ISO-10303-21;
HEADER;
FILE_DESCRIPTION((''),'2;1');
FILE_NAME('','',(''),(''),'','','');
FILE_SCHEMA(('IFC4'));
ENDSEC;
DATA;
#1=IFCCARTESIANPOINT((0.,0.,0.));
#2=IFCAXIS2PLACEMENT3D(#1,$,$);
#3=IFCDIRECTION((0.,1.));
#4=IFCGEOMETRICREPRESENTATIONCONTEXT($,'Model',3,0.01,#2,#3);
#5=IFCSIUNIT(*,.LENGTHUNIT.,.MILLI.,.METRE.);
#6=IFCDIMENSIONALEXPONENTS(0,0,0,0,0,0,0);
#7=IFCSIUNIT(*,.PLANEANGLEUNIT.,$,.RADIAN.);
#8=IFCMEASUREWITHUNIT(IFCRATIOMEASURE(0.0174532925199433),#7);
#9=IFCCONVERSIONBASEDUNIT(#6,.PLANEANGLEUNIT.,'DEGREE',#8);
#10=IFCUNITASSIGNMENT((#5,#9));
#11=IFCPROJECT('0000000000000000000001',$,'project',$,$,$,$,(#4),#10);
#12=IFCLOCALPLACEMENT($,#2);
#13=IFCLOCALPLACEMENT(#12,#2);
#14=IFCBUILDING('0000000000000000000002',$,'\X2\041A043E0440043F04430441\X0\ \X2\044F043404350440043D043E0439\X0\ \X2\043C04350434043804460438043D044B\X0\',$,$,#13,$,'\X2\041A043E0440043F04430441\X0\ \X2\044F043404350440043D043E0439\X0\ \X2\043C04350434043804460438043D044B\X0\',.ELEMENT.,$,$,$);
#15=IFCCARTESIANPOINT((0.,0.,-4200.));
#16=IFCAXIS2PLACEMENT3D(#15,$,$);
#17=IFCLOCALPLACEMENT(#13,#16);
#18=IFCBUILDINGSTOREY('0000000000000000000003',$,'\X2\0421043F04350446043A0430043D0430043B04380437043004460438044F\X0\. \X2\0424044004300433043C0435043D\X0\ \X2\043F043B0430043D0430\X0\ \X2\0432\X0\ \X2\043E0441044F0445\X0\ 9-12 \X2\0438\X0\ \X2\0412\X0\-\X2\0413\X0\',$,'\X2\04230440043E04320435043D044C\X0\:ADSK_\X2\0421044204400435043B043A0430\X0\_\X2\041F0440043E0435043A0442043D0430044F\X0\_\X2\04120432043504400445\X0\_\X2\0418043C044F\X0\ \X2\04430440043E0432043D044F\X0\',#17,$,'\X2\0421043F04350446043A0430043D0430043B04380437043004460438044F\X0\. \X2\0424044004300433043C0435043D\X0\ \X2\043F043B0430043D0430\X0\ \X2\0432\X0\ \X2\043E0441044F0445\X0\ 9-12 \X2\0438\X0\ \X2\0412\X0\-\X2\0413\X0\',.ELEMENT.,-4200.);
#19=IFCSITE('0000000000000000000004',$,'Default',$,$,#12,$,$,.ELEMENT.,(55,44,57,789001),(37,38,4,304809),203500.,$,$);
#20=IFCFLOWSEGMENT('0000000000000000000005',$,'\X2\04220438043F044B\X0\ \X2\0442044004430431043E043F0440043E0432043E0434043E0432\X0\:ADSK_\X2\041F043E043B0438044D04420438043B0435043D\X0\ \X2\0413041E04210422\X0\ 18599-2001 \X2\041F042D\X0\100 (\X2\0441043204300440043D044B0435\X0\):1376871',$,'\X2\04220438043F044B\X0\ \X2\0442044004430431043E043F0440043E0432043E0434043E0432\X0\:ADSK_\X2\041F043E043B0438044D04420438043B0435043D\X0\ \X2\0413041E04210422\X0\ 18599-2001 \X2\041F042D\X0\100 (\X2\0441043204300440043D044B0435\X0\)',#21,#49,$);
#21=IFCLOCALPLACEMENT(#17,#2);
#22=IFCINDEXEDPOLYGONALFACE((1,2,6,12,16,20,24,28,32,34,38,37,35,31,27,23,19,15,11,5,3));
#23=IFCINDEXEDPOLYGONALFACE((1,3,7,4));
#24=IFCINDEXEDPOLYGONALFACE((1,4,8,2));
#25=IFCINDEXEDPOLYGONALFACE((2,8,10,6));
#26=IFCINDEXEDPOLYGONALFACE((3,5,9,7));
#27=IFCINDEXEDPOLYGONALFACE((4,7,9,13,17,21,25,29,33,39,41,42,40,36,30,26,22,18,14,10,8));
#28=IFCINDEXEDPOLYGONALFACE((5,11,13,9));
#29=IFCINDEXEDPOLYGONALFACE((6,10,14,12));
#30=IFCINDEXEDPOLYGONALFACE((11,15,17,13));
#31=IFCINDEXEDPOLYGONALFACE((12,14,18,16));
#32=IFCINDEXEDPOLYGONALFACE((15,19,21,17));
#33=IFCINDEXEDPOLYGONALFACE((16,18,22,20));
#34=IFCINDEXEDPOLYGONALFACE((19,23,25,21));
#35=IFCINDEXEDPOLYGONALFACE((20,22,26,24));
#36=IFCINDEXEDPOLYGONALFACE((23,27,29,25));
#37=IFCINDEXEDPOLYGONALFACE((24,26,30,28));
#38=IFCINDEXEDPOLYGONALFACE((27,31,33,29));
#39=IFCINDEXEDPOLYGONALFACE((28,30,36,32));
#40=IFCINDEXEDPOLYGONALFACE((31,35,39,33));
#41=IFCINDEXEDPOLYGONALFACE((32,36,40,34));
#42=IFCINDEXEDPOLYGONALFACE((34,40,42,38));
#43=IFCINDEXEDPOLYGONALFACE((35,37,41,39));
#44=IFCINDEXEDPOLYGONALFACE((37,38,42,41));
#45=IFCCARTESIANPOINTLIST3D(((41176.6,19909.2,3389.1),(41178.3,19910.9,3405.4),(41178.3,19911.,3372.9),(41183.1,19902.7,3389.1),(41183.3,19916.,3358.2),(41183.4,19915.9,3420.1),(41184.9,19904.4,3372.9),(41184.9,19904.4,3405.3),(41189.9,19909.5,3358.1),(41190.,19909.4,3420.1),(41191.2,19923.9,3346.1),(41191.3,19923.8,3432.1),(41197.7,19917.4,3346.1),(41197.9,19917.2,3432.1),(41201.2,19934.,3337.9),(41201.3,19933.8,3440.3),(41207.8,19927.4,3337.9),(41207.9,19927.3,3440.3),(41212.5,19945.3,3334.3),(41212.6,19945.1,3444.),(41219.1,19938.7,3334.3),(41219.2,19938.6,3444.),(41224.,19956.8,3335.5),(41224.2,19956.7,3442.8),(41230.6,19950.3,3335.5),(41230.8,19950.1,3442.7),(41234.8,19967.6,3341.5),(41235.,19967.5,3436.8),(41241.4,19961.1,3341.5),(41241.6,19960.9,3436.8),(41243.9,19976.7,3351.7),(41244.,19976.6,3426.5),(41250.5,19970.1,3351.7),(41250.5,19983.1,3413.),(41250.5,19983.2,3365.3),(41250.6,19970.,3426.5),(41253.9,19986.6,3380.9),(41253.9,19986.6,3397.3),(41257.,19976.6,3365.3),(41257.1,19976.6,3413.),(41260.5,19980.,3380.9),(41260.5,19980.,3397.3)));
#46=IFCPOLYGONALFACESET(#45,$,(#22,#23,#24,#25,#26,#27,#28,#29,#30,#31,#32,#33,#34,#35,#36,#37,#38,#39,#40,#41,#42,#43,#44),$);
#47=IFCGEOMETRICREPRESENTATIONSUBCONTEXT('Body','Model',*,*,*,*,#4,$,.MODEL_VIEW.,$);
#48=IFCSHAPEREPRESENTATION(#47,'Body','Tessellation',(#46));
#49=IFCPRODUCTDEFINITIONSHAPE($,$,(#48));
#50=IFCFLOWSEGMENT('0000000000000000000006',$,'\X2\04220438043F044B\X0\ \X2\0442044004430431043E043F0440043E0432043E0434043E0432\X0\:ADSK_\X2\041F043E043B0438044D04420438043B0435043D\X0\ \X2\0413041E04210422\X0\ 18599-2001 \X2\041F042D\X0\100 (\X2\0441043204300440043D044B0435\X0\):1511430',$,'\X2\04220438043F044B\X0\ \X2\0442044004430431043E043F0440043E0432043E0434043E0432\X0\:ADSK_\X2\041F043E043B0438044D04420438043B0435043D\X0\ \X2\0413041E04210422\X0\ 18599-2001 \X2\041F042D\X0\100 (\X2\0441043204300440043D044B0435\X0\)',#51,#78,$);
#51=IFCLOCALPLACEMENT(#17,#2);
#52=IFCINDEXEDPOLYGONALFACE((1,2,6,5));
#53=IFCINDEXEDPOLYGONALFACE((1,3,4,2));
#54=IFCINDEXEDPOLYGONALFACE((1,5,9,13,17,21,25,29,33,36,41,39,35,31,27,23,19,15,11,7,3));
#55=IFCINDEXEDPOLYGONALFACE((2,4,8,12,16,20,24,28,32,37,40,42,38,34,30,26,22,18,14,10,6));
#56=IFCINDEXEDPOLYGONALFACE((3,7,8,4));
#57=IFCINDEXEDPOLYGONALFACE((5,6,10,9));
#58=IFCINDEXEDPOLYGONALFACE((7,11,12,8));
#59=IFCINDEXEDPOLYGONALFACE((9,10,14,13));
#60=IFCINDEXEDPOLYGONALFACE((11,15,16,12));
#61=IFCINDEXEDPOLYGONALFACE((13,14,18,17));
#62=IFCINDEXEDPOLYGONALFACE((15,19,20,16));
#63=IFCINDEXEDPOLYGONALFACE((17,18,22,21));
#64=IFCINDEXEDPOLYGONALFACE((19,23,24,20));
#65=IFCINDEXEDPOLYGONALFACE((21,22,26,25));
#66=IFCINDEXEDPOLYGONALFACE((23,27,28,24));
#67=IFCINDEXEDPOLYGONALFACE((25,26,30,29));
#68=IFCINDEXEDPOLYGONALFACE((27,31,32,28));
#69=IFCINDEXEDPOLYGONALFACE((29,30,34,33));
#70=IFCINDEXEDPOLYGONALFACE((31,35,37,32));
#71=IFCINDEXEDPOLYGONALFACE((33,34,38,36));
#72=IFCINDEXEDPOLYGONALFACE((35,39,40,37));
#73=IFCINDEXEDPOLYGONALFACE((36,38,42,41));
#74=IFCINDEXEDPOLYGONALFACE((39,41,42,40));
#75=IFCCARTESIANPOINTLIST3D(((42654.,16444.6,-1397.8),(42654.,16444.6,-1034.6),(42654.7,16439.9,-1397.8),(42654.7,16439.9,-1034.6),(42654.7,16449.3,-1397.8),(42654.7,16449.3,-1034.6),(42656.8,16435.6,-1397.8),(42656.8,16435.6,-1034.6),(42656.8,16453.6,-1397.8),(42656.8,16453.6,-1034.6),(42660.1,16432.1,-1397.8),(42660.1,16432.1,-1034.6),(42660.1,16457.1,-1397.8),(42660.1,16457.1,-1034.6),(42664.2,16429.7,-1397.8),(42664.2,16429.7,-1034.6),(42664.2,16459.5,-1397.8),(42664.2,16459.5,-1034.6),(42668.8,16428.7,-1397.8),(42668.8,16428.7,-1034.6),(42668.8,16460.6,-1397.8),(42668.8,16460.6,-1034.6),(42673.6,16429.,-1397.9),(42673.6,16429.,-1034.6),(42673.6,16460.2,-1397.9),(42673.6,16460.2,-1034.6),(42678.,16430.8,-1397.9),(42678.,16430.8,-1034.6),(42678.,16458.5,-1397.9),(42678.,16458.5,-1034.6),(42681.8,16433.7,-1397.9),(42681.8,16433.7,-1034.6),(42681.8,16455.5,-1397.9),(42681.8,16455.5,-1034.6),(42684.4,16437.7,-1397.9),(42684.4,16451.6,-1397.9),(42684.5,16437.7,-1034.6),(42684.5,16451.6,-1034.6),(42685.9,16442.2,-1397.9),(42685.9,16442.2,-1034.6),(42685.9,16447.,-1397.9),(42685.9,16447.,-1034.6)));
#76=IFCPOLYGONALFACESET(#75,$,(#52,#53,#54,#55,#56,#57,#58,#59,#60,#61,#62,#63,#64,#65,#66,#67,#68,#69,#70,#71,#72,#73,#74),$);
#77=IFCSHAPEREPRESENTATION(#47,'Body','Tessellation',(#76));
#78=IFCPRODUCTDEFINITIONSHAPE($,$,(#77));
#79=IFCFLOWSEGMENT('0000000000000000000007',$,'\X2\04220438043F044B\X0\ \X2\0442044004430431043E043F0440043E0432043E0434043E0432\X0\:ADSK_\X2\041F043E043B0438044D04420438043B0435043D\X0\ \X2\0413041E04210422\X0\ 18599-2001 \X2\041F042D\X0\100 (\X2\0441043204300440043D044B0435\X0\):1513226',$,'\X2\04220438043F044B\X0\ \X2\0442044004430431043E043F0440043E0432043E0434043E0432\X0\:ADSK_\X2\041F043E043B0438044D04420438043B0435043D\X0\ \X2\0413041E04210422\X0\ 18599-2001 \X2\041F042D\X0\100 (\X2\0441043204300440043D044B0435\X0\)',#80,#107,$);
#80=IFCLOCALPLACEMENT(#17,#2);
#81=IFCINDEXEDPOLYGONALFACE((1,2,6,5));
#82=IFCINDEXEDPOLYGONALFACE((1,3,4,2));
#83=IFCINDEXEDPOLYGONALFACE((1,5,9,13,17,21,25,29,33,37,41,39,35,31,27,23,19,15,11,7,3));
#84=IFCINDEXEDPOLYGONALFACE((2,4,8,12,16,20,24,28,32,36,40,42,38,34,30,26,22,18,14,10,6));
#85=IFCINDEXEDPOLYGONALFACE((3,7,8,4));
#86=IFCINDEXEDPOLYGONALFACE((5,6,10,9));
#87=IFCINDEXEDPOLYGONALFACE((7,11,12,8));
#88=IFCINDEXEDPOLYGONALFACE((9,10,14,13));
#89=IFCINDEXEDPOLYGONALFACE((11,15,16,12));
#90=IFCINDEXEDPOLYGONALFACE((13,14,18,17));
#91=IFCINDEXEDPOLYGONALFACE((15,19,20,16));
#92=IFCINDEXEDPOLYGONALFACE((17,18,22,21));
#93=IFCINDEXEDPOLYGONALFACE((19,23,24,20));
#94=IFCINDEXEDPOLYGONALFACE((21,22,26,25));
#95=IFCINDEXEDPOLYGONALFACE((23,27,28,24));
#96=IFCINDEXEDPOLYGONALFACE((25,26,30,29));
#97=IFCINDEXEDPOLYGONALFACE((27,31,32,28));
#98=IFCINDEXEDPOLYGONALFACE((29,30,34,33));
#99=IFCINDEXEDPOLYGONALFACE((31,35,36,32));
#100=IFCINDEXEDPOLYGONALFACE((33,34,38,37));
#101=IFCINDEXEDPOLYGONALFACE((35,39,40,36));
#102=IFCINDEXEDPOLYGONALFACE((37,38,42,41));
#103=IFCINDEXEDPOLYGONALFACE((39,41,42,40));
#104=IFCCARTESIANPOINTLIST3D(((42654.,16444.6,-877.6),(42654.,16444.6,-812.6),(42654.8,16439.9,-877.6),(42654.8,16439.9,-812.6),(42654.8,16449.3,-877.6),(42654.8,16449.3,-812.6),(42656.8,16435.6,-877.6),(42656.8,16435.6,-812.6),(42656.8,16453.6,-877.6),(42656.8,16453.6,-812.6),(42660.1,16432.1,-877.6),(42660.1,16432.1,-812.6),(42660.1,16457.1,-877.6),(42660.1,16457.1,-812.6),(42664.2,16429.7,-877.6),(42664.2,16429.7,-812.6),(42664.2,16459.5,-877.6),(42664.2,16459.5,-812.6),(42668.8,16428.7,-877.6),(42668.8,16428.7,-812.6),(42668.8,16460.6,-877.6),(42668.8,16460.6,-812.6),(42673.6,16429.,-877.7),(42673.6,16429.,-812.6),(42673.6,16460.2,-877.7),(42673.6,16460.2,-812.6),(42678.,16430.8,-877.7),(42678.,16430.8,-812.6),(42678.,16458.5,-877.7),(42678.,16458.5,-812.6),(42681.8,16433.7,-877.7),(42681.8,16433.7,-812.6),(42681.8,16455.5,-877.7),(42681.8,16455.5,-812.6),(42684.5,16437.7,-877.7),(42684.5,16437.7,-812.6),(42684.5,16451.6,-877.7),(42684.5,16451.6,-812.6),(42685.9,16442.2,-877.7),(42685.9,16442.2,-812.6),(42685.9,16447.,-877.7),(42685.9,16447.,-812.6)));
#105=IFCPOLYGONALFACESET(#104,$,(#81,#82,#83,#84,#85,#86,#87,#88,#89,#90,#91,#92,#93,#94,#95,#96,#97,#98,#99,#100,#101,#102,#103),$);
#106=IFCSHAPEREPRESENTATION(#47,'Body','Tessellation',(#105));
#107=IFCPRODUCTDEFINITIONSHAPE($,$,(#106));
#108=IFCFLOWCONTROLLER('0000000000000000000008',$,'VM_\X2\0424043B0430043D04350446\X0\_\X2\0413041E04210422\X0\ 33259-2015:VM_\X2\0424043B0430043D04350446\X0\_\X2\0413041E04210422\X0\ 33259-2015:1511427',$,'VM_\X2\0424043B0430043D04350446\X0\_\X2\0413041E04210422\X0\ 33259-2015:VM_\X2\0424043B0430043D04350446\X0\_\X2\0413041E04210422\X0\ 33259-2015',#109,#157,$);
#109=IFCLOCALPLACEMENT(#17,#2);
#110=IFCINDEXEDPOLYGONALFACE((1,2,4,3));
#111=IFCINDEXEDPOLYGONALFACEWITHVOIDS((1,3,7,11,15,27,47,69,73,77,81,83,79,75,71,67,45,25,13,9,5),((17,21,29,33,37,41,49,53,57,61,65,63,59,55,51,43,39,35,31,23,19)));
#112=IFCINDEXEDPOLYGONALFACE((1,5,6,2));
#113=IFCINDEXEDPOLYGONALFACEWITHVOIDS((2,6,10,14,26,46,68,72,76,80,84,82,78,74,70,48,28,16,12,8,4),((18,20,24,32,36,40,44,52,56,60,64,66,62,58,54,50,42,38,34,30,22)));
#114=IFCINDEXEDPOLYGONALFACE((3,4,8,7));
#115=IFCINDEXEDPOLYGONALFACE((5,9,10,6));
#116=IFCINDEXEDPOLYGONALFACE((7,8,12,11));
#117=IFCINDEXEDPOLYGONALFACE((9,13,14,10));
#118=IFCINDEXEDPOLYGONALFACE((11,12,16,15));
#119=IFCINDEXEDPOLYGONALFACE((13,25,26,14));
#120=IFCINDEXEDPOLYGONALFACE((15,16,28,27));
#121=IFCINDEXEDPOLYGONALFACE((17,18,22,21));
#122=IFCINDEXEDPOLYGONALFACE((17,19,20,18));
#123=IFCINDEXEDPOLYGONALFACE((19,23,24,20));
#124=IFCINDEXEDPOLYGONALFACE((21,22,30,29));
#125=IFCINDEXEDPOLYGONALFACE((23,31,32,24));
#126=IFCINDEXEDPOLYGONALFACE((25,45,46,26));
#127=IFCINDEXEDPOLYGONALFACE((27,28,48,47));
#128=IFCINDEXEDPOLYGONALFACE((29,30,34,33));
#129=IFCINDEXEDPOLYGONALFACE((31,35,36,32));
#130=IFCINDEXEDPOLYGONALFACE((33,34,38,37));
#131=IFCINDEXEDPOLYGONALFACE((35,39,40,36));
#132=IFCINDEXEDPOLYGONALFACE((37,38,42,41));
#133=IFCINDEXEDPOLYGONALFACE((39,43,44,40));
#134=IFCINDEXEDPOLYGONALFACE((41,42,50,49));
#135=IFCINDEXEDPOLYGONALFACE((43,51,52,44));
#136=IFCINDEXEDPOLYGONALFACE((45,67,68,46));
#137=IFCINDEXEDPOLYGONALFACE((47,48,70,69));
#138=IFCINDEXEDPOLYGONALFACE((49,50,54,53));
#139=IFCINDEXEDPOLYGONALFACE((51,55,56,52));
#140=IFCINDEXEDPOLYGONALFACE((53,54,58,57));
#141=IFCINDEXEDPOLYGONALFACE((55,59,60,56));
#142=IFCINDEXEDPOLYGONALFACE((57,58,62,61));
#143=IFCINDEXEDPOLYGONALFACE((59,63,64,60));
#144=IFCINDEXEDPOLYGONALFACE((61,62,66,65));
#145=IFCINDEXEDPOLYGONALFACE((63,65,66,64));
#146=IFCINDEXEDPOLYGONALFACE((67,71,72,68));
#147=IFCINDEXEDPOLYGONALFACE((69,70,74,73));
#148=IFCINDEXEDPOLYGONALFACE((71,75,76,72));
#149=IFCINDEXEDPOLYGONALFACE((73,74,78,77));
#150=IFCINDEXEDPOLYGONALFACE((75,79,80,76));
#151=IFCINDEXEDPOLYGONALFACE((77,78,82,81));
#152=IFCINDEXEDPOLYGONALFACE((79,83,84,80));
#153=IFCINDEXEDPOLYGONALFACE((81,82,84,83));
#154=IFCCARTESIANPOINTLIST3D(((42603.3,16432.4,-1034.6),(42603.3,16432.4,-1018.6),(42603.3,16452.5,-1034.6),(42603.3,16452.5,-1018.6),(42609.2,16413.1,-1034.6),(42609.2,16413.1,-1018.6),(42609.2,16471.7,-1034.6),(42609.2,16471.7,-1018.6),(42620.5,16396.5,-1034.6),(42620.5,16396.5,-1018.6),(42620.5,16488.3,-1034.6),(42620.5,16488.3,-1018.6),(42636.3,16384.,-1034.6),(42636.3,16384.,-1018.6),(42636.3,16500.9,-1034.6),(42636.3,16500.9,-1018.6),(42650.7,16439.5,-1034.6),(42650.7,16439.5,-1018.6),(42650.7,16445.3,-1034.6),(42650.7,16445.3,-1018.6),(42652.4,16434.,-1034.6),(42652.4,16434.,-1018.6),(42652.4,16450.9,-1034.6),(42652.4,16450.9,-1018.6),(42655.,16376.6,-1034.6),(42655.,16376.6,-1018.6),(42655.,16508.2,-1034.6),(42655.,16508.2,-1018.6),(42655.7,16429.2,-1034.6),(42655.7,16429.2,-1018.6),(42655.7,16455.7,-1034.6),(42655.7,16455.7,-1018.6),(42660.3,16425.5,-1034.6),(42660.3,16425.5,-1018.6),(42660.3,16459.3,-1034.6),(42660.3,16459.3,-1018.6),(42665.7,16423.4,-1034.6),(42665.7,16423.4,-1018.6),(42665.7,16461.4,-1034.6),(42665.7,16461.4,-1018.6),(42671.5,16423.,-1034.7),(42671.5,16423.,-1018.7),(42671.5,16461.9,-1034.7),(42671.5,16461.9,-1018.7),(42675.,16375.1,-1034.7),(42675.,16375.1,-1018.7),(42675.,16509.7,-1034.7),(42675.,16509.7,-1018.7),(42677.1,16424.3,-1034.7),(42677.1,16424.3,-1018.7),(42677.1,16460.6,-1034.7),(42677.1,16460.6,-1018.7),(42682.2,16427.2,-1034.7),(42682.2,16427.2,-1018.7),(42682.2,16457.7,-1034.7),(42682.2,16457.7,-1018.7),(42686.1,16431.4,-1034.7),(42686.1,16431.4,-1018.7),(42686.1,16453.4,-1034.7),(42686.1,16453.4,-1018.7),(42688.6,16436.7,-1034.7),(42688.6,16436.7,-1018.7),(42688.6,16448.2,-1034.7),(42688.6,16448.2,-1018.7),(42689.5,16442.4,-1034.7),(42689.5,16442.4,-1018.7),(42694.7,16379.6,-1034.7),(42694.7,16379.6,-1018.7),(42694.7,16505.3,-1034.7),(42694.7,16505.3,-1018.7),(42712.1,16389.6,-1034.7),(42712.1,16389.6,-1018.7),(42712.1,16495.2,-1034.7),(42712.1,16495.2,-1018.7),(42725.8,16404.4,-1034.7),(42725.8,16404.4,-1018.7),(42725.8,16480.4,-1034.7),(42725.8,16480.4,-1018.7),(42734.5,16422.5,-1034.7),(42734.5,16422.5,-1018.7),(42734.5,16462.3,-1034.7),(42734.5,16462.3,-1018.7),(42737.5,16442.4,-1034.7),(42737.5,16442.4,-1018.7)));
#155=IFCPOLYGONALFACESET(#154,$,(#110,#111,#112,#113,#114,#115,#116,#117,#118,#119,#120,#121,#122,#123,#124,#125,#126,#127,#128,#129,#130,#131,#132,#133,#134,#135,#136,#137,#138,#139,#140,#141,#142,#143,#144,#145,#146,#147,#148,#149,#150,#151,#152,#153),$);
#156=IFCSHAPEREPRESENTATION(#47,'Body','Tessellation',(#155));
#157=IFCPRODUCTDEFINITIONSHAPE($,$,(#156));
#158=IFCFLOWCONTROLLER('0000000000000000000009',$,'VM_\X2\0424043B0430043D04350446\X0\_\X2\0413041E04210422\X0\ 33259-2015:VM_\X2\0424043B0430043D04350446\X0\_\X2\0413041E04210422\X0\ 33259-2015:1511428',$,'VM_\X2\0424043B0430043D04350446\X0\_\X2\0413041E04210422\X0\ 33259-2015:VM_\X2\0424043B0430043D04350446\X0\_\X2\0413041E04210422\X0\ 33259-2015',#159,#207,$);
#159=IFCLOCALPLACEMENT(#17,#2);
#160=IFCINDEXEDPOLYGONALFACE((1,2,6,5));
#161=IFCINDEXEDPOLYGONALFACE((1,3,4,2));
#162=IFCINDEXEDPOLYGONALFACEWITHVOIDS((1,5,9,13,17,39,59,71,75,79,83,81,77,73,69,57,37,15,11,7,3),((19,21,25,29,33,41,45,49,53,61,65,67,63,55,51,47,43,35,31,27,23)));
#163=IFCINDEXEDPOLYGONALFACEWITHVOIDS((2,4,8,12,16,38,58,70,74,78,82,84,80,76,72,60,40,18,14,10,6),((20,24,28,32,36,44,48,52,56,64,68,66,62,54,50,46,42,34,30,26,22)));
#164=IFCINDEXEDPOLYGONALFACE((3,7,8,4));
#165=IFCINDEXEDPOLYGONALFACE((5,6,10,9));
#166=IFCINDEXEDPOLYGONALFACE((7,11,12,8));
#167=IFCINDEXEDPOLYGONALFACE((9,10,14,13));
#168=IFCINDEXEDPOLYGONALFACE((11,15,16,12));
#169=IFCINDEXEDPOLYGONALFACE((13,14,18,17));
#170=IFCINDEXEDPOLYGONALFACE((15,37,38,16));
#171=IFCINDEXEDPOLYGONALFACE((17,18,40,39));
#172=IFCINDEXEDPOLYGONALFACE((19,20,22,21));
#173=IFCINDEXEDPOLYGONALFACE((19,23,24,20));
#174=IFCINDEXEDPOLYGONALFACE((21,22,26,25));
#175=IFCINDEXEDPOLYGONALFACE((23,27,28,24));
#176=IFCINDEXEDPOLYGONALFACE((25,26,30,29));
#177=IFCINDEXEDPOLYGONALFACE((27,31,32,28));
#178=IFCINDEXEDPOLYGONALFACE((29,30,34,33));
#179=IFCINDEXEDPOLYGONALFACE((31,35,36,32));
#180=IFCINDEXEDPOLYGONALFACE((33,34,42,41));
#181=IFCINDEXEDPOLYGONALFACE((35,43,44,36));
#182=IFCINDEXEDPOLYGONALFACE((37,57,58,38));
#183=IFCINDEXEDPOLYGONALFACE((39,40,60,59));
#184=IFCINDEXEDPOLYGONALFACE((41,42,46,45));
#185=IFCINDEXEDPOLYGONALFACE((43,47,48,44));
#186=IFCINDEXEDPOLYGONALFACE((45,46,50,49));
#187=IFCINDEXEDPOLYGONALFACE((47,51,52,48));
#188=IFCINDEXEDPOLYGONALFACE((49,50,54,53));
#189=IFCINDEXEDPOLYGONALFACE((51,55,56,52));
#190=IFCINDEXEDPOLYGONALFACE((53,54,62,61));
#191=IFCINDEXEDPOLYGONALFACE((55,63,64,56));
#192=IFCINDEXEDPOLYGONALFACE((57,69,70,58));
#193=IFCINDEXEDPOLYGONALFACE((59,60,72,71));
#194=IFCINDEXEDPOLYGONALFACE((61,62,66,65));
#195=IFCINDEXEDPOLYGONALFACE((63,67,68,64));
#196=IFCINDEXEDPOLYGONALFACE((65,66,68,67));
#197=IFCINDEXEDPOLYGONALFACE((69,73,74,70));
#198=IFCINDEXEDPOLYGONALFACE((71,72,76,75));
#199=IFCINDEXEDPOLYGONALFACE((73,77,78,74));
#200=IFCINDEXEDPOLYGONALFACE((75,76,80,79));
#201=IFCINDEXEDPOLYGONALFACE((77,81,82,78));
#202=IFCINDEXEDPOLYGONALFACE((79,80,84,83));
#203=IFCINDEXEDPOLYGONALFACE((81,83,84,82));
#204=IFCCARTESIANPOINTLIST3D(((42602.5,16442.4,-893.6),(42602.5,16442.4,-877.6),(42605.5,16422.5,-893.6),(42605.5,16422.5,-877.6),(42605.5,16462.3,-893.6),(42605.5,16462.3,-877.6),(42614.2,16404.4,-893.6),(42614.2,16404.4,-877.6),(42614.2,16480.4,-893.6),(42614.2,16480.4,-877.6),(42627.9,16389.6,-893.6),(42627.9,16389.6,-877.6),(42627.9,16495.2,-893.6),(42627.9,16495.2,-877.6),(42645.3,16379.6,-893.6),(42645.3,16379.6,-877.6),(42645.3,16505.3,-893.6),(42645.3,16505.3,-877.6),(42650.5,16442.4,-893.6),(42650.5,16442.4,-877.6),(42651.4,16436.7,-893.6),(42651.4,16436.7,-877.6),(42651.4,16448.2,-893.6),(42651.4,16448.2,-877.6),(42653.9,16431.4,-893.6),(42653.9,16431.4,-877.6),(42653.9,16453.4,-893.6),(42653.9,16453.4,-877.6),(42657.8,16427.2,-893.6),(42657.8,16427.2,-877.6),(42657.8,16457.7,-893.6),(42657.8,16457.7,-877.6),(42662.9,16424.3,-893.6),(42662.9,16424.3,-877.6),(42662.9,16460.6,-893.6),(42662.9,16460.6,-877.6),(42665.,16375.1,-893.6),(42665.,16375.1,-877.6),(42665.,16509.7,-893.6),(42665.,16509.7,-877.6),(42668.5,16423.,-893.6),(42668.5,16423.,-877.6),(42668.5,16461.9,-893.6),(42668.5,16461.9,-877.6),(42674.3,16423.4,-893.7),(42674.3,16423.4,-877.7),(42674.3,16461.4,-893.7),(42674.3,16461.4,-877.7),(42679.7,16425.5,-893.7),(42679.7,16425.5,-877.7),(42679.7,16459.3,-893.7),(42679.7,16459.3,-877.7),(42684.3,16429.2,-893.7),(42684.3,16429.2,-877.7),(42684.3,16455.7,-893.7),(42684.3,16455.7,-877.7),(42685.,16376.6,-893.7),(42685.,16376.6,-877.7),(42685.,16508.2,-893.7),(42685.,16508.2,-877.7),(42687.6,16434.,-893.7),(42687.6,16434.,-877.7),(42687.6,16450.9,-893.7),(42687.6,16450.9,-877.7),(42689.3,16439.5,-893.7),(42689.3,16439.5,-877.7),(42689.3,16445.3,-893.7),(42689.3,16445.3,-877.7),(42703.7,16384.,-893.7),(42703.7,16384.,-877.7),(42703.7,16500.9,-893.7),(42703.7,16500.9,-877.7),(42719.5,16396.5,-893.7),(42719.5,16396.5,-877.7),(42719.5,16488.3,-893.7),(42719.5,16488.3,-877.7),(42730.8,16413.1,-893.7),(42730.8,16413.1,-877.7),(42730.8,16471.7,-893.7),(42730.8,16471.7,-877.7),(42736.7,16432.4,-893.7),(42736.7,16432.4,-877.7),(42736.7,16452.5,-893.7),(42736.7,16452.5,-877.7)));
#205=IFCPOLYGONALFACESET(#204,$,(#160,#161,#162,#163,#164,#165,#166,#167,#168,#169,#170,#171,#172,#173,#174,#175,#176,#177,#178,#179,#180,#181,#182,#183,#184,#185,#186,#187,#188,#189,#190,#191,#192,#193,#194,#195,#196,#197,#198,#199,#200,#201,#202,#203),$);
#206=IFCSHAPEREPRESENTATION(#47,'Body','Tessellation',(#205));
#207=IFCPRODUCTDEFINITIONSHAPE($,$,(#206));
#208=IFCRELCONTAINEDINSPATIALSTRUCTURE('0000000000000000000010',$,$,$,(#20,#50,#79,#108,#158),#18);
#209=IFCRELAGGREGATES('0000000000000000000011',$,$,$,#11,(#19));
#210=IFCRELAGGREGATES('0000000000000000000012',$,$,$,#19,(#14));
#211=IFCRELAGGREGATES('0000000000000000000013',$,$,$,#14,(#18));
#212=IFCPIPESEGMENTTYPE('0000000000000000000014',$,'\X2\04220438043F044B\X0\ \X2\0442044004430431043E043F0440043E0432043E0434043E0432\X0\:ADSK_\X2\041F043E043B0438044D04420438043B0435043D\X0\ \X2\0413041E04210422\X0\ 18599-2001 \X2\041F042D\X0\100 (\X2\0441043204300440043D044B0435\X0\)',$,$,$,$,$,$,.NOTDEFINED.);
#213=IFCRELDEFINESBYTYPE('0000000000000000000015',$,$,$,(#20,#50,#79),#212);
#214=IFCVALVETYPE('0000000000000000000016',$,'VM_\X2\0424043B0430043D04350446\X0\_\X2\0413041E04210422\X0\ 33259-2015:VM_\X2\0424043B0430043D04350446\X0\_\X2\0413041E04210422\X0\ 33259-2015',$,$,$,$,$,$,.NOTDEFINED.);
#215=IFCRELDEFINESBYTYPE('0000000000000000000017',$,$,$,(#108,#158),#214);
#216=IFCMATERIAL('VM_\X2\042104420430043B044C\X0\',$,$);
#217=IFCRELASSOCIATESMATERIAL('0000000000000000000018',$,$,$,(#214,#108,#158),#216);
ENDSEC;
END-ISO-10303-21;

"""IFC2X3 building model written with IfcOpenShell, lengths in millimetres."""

from ifc_helpers import new_model, entity, si_unit, converted_unit, direction, frame, origin, origin_2d_with_axis, place, context, subcontext, project, spatial, circle, hollow_circle, extrude, source, transform, mapped, material, type_object, type_shapes, element, save


model = new_model("IFC2X3")

# Units and contexts
model_context = context("Model", 3, precision=0.01, world=origin(), true_north=direction((0.0, 1.0)))
body_context = subcontext(model_context, "Body", "Model", "MODEL_VIEW")
ifc_project = project(units=[si_unit("LENGTHUNIT", "METRE", prefix="MILLI"), converted_unit("PLANEANGLEUNIT", "DEGREE", entity("IfcRatioMeasure", 0.0174532925199433), si_unit("PLANEANGLEUNIT", "RADIAN"), dimensions=[0, 0, 0, 0, 0, 0, 0])], contexts=[model_context])

# Site, building, storey
site_placement = place(None, origin())
site = spatial("IfcSite", under=ifc_project, at=site_placement, Name="Default", CompositionType="ELEMENT", RefLatitude=(55, 44, 57, 789001), RefLongitude=(37, 38, 4, 304809), RefElevation=203500.0)
building_placement = place(site_placement, origin())
building = spatial("IfcBuilding", under=site, at=building_placement, Name="Корпус ядерной медицины", LongName="Корпус ядерной медицины", CompositionType="ELEMENT")
storey_placement = place(building_placement, frame((0.0, 0.0, -4200.0)))
storey = spatial("IfcBuildingStorey", under=building, at=storey_placement, Name="Спецканализация. Фрагмен плана в осях 9-12 и В-Г", ObjectType="Уровень:ADSK_Стрелка_Проектная_Вверх_Имя уровня", LongName="Спецканализация. Фрагмен плана в осях 9-12 и В-Г", CompositionType="ELEMENT", Elevation=-4200.0)

# Flow segments
pipe_segment_type = type_object("IfcPipeSegmentType", Name="Типы трубопроводов:ADSK_Полиэтилен ГОСТ 18599-2001 ПЭ100 (сварные)", PredefinedType="NOTDEFINED")
flow_segment_1_placement = place(storey_placement, frame((41175.0, 19901.1, 3332.5)))
element("IfcFlowSegment", 1, at=flow_segment_1_placement, inside=storey, type_object=pipe_segment_type, Name="Типы трубопроводов:ADSK_Полиэтилен ГОСТ 18599-2001 ПЭ100 (сварные):1376871", ObjectType="Типы трубопроводов:ADSK_Полиэтилен ГОСТ 18599-2001 ПЭ100 (сварные)", context=body_context, shape_type="SweptSolid", body=[
    extrude(circle(Radius=55.0, at=origin_2d_with_axis()), frame((47.0, 40.5, 56.6), z_axis=(-0.707105, 0.707105, 0.002), x_axis=(-0.707107, -0.707107, 0.0)), (0.0, 0.0, 1.0), 9.3),
])
flow_segment_2_placement = place(storey_placement, frame((42652.4, 16427.0, -1397.8)))
element("IfcFlowSegment", 2, at=flow_segment_2_placement, inside=storey, type_object=pipe_segment_type, Name="Типы трубопроводов:ADSK_Полиэтилен ГОСТ 18599-2001 ПЭ100 (сварные):1511430", ObjectType="Типы трубопроводов:ADSK_Полиэтилен ГОСТ 18599-2001 ПЭ100 (сварные)", context=body_context, shape_type="SweptSolid", body=[
    extrude(circle(Radius=16.0, at=origin_2d_with_axis()), frame((17.6, 17.6, 0.0), z_axis=(0.000013, 0.0, 1.0), x_axis=(-1.0, 0.0, 0.000013)), (0.0, 0.0, 1.0), 363.2),
])
flow_segment_3_placement = place(storey_placement, frame((42652.4, 16427.0, -877.6)))
element("IfcFlowSegment", 3, at=flow_segment_3_placement, inside=storey, type_object=pipe_segment_type, Name="Типы трубопроводов:ADSK_Полиэтилен ГОСТ 18599-2001 ПЭ100 (сварные):1513226", ObjectType="Типы трубопроводов:ADSK_Полиэтилен ГОСТ 18599-2001 ПЭ100 (сварные)", context=body_context, shape_type="SweptSolid", body=[
    extrude(circle(Radius=16.0, at=origin_2d_with_axis()), frame((17.6, 17.6, 0.0), z_axis=(0.000017, 0.0, 1.0), x_axis=(-1.0, 0.0, 0.000017)), (0.0, 0.0, 1.0), 65.1),
])

# Flow controllers
ifc_material_1 = material(Name="VM_Сталь")
valve_type_1 = type_object("IfcValveType", Name="VM_Фланец_ГОСТ 33259-2015:VM_Фланец_ГОСТ 33259-2015", PredefinedType="NOTDEFINED", material=ifc_material_1)
shared_shape_1 = source(origin(), body_context, "Body", "SweptSolid", [
    extrude(hollow_circle(Radius=67.5, WallThickness=48.0, at=origin_2d_with_axis()), frame((0.0, 0.0, 0.0), z_axis=(1.0, 0.0, 0.0), x_axis=(0.0, 1.0, 0.0)), (0.0, 0.0, 1.0), 16.0),
])
type_shapes(valve_type_1, [shared_shape_1])
for number, where, z_axis, x_axis, name in (
    (4, (42670.0, 16442.4, -1034.7), (0.0, 1.0, 0.0), (0.000013, 0.0, 1.0), "VM_Фланец_ГОСТ 33259-2015:VM_Фланец_ГОСТ 33259-2015:1511427"),
    (5, (42670.0, 16442.4, -877.6), (0.0, 1.0, 0.0), (-0.000013, 0.0, -1.0), "VM_Фланец_ГОСТ 33259-2015:VM_Фланец_ГОСТ 33259-2015:1511428"),
):
    element("IfcFlowController", number, at=place(storey_placement, frame(where, z_axis=z_axis, x_axis=x_axis)), inside=storey, type_object=valve_type_1, material=ifc_material_1, Name=name, ObjectType="VM_Фланец_ГОСТ 33259-2015:VM_Фланец_ГОСТ 33259-2015", context=body_context, shape_type="MappedRepresentation", body=[
        mapped(shared_shape_1, transform((0.0, 0.0, 0.0), scale=1.0)),
    ])

save(model, "model.ifc")
